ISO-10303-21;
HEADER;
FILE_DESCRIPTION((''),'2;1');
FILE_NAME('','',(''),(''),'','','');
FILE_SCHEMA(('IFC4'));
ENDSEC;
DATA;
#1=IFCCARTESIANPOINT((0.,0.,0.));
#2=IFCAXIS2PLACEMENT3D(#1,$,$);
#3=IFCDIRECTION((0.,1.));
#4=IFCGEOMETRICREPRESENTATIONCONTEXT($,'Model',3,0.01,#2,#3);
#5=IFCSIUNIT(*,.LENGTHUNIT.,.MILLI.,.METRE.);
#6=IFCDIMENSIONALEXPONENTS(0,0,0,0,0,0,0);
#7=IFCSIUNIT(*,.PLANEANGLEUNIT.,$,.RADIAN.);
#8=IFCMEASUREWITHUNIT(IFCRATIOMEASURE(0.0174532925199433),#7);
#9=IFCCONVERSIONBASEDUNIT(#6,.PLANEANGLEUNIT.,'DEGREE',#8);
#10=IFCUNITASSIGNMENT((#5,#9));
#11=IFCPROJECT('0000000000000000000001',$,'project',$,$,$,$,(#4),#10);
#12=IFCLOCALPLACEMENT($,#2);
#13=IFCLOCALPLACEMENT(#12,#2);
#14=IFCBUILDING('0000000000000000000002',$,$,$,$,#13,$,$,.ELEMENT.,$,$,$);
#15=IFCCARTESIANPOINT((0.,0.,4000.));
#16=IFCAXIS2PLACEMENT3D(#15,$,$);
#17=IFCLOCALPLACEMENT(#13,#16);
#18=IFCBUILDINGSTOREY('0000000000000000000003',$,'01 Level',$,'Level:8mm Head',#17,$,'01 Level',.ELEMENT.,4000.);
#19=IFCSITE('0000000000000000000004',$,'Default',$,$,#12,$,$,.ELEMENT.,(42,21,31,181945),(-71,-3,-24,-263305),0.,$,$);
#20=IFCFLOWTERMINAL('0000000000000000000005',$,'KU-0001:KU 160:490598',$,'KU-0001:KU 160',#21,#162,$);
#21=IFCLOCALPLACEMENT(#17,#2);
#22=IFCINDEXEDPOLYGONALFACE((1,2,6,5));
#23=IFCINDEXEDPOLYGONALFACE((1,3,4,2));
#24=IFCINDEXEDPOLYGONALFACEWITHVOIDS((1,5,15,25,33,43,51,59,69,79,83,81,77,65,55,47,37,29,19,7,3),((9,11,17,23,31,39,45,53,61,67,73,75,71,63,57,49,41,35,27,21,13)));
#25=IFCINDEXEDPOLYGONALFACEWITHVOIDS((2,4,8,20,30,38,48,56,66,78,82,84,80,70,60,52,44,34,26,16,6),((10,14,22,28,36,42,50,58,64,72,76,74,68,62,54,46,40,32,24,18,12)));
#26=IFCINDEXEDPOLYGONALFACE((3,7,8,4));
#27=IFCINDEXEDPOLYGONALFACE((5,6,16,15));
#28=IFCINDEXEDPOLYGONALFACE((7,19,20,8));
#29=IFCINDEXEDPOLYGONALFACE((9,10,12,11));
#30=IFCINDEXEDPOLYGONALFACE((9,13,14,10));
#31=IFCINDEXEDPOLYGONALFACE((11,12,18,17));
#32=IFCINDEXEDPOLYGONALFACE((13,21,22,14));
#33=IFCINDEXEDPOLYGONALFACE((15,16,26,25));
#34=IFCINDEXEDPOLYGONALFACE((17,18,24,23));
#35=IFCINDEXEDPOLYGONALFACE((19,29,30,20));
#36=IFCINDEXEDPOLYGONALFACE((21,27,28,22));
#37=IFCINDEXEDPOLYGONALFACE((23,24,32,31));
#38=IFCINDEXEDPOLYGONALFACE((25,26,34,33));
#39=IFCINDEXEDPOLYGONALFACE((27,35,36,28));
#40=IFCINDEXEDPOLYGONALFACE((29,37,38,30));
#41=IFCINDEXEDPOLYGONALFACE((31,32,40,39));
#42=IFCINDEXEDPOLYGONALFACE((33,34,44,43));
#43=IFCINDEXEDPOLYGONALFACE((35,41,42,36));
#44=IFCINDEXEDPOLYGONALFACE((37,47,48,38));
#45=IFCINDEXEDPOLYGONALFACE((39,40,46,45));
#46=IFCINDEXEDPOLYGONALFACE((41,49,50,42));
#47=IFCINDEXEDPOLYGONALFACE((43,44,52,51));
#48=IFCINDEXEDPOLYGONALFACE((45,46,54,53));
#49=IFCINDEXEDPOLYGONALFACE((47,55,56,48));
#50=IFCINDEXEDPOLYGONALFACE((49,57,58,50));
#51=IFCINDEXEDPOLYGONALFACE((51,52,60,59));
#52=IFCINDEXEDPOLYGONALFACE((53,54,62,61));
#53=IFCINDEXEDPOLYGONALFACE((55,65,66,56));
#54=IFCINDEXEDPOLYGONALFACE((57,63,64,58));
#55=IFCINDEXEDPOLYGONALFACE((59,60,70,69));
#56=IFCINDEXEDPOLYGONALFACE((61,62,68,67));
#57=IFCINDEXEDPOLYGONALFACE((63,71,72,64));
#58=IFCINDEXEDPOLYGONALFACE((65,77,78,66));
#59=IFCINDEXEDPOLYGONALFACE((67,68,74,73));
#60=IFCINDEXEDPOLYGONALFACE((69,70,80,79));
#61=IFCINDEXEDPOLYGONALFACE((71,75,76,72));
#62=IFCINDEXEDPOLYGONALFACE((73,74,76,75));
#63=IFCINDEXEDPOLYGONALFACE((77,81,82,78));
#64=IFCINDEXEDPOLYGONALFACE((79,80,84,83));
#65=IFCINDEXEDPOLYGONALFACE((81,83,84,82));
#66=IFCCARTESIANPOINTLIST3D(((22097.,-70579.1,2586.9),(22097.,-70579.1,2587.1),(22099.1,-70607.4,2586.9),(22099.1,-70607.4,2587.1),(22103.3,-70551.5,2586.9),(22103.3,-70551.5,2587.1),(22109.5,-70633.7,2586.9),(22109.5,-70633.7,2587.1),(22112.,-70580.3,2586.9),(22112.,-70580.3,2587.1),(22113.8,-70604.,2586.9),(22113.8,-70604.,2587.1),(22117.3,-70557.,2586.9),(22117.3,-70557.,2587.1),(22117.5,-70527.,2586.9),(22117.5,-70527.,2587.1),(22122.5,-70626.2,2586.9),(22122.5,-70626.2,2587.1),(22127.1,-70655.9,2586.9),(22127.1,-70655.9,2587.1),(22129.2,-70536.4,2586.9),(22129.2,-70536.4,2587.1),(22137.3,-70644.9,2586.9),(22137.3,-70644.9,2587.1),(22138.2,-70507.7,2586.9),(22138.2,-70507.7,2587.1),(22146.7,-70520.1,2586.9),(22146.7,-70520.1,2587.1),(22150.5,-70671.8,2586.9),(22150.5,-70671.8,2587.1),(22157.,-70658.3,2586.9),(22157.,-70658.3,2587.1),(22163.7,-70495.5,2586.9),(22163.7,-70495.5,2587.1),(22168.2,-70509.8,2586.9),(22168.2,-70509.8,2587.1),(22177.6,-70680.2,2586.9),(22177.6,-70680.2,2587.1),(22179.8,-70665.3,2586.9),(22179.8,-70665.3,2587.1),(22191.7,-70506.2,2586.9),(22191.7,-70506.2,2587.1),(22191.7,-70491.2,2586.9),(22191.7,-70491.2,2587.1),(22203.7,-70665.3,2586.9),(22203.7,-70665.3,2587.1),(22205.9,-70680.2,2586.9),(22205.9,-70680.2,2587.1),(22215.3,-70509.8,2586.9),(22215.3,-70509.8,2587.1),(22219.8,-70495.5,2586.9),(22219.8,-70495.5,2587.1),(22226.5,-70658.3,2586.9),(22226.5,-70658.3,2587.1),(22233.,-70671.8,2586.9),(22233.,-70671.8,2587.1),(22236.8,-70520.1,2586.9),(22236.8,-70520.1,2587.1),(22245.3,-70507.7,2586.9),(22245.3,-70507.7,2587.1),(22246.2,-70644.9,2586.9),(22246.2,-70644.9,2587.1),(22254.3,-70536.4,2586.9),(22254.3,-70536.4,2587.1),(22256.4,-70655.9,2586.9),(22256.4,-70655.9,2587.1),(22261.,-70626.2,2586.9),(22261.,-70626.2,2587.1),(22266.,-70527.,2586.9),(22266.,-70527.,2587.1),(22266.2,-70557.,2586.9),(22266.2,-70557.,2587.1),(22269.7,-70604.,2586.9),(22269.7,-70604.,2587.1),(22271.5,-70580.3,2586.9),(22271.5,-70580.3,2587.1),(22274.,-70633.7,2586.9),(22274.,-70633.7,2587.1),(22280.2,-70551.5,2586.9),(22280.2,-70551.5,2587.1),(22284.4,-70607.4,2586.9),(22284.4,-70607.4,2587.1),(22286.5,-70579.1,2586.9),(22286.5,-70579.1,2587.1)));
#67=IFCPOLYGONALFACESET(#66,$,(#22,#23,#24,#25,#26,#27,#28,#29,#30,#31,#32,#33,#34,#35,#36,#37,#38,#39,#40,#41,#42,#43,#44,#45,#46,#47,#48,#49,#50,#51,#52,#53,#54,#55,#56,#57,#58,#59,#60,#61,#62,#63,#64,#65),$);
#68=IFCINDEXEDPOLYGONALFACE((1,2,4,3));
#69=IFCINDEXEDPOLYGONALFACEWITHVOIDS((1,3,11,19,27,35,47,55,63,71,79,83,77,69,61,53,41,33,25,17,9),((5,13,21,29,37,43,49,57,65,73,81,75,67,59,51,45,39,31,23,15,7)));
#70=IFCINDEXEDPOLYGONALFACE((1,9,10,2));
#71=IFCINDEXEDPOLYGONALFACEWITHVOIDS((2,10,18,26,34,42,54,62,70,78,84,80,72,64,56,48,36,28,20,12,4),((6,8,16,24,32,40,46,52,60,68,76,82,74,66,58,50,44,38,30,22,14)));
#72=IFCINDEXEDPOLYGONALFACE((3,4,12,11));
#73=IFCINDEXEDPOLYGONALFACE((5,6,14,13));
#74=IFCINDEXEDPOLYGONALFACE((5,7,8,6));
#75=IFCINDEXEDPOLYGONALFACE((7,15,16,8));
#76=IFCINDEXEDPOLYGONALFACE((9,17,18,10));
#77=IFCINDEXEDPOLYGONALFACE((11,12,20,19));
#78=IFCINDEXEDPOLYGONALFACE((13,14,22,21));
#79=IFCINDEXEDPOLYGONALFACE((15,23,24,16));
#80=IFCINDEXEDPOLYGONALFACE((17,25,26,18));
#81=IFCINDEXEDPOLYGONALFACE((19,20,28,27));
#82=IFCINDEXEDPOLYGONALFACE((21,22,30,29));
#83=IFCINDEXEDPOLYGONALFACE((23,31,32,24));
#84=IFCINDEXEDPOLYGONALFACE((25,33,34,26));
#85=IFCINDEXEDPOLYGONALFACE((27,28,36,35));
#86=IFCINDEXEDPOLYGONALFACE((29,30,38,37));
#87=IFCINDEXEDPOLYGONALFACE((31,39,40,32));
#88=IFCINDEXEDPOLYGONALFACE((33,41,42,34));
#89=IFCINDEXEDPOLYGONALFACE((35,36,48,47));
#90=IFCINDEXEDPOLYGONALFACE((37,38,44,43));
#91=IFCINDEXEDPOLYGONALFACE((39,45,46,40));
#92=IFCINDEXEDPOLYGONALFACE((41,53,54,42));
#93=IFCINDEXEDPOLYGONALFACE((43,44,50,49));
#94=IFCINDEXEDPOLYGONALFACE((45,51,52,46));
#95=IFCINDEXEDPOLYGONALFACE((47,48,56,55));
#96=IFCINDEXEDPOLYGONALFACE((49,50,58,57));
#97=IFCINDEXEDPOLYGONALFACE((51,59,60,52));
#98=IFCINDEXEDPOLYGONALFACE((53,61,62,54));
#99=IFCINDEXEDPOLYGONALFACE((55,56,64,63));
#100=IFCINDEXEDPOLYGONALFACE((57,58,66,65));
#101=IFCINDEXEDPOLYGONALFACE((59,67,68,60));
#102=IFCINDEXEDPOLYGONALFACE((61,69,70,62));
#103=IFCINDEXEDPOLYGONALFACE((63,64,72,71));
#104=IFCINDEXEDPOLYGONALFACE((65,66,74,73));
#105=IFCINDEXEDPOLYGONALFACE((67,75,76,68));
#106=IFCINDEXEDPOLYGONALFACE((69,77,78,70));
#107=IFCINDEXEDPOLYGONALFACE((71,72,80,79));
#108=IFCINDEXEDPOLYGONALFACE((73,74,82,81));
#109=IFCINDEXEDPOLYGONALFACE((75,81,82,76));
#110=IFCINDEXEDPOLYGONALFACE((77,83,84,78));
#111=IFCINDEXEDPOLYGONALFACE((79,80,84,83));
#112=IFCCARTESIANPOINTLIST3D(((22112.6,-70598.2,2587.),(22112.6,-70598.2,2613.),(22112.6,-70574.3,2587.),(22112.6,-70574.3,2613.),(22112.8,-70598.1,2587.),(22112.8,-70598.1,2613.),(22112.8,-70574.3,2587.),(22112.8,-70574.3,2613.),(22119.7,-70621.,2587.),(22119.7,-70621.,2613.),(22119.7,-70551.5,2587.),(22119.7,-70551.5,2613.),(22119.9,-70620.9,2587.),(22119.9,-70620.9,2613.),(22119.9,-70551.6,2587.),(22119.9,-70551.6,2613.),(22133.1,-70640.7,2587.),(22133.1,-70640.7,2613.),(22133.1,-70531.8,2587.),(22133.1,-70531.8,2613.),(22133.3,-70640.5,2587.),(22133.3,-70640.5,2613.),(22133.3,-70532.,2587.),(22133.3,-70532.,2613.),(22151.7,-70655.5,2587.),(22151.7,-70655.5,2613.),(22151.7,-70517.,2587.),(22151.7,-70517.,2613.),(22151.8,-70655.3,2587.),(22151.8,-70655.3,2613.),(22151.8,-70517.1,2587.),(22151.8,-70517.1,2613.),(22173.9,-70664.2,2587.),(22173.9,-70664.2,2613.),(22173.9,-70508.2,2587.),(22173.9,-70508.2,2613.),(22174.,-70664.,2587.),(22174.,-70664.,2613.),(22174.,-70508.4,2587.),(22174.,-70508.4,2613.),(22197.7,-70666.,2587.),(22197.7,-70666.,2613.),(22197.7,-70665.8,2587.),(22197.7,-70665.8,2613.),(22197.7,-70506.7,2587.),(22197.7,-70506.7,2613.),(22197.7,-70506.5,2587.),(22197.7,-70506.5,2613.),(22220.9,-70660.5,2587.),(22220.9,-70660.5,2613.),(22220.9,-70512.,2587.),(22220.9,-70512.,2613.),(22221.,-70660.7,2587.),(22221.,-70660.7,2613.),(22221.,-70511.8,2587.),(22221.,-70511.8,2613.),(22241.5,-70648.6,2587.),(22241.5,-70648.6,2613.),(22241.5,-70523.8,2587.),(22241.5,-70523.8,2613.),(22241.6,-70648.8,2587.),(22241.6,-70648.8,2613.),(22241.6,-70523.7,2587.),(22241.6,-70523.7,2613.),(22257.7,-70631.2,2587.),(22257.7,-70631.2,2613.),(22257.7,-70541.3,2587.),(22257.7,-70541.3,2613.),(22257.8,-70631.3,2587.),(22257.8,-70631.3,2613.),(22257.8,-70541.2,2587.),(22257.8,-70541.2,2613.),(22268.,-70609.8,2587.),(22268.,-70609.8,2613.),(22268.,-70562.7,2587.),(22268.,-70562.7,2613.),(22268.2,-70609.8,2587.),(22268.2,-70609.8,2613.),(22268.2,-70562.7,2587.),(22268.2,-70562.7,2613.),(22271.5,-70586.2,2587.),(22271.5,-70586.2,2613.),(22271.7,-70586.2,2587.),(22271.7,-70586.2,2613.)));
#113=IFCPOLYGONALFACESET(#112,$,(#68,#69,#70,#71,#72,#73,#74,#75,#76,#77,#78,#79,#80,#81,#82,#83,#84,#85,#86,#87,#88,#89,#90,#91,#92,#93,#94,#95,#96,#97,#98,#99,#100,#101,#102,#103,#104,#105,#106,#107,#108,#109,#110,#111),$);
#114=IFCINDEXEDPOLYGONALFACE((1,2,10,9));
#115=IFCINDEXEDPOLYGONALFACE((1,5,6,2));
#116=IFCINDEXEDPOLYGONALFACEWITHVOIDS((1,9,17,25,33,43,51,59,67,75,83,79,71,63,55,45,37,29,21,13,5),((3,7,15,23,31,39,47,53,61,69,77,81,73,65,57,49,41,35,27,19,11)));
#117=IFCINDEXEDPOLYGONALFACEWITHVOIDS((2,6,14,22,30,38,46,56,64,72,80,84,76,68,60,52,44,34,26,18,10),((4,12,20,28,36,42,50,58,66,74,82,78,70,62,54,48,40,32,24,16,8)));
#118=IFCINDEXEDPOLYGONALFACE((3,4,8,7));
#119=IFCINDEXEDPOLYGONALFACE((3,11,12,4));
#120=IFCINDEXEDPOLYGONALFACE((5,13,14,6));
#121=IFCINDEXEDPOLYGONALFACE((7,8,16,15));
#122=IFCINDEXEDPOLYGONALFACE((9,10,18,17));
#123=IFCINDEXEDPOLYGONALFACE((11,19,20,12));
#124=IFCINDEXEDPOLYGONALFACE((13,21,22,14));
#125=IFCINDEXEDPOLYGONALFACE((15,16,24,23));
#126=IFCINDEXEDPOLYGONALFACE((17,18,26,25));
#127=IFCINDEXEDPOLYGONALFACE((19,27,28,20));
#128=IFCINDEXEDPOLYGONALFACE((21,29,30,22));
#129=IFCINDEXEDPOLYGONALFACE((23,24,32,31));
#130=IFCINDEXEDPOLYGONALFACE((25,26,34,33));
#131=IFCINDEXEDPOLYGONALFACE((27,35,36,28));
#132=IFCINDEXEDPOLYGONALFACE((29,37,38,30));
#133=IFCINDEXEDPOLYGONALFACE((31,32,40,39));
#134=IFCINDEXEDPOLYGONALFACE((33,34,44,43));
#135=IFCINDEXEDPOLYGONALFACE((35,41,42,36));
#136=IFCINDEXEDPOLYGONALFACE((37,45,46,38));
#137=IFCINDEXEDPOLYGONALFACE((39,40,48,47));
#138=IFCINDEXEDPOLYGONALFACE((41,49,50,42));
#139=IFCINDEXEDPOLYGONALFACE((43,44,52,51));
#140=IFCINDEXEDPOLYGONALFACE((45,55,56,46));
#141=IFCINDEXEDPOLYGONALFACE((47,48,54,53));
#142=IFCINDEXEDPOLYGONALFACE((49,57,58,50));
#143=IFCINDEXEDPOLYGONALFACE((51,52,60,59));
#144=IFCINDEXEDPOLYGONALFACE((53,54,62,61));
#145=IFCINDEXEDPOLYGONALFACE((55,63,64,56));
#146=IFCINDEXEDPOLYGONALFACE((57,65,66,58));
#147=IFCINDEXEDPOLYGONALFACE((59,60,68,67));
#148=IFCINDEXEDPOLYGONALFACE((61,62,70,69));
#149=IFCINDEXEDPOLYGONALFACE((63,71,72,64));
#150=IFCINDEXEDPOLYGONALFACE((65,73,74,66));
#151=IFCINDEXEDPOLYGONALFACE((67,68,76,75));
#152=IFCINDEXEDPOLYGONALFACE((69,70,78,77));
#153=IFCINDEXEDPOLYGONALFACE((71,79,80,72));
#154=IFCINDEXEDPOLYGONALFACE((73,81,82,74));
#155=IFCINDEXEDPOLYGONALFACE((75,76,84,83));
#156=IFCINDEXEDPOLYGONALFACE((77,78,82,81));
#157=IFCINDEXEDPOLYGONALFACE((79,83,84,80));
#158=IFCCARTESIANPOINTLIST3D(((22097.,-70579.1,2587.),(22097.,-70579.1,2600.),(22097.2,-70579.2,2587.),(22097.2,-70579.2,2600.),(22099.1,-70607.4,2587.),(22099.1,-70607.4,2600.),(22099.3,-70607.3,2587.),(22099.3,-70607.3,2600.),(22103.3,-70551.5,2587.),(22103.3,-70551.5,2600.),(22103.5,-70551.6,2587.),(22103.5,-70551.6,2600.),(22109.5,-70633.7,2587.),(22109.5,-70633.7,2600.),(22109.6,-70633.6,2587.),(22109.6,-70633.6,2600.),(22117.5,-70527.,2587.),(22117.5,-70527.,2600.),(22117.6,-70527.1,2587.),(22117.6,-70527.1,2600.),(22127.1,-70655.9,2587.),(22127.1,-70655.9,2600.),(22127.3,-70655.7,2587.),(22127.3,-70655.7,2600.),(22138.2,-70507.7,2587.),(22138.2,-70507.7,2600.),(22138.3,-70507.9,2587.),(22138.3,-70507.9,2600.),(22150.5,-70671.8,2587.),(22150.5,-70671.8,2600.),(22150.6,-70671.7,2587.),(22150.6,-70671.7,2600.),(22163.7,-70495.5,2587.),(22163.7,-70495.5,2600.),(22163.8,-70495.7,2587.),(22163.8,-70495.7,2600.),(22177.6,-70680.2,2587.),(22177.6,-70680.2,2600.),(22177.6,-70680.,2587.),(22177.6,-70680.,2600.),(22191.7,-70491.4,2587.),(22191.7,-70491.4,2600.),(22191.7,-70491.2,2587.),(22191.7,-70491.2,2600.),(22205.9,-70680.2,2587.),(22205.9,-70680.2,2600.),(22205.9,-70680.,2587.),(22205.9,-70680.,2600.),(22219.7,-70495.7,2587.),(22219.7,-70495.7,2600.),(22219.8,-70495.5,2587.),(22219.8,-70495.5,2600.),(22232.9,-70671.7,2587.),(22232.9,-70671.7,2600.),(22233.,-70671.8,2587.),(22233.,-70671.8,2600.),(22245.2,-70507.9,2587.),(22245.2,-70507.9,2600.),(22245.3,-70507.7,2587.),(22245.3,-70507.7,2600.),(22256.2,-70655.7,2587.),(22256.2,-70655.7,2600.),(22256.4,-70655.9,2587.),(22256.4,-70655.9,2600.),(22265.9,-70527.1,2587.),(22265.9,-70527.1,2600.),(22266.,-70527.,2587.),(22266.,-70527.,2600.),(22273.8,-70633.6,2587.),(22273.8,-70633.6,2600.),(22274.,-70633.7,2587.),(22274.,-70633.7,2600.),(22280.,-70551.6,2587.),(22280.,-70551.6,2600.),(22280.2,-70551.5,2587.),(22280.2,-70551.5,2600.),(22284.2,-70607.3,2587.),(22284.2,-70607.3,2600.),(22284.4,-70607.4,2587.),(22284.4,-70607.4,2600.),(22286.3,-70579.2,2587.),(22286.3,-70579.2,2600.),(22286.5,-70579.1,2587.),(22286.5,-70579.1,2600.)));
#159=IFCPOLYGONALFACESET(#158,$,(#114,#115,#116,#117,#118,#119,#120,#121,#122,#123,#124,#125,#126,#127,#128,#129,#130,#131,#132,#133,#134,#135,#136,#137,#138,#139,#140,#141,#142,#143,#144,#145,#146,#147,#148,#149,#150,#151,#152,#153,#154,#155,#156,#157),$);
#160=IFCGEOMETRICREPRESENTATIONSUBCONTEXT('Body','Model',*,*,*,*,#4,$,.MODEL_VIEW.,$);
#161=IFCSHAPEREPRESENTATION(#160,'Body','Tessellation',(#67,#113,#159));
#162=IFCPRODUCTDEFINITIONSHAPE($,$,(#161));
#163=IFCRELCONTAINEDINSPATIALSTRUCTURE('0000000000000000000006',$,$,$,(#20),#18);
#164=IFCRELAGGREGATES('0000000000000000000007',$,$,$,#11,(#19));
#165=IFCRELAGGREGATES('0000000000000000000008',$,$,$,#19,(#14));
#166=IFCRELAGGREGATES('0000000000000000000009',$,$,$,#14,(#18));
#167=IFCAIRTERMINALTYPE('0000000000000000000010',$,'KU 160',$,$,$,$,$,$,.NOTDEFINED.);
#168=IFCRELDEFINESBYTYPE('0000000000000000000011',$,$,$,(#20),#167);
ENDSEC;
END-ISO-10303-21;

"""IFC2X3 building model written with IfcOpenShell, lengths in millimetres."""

from ifc_helpers import new_model, entity, si_unit, converted_unit, direction, frame, frame_2d, origin, place, context, subcontext, project, spatial, hollow_circle, extrude, source, transform, mapped, type_object, type_shapes, element, save


model = new_model("IFC2X3")

# Units and contexts
model_context = context("Model", 3, precision=0.01, world=origin(), true_north=direction((0.0, 1.0)))
body_context = subcontext(model_context, "Body", "Model", "MODEL_VIEW")
ifc_project = project(units=[si_unit("LENGTHUNIT", "METRE", prefix="MILLI"), converted_unit("PLANEANGLEUNIT", "DEGREE", entity("IfcRatioMeasure", 0.0174532925199433), si_unit("PLANEANGLEUNIT", "RADIAN"), dimensions=[0, 0, 0, 0, 0, 0, 0])], contexts=[model_context])

# Site, building, storey
site_placement = place(None, origin())
site = spatial("IfcSite", under=ifc_project, at=site_placement, Name="Default", CompositionType="ELEMENT", RefLatitude=(42, 21, 31, 181945), RefLongitude=(-71, -3, -24, -263305), RefElevation=0.0)
building_placement = place(site_placement, origin())
building = spatial("IfcBuilding", under=site, at=building_placement, CompositionType="ELEMENT")
storey_placement = place(building_placement, frame((0.0, 0.0, 4000.0)))
storey = spatial("IfcBuildingStorey", under=building, at=storey_placement, Name="01 Level", ObjectType="Level:8mm Head", LongName="01 Level", CompositionType="ELEMENT", Elevation=4000.0)

# Flow terminal
air_terminal_type_1 = type_object("IfcAirTerminalType", Name="KU 160", PredefinedType="NOTDEFINED")
shared_shape_1 = source(origin(), body_context, "Body", "SweptSolid", [
    extrude(hollow_circle(Radius=95.0, WallThickness=15.0, at=frame_2d((0.0, 0.0), x_axis=(1.0, 0.0))), frame((12.9, 0.0, 0.0), z_axis=(1.0, 0.0, 0.0), x_axis=(0.0, 1.0, 0.0)), (0.0, 0.0, 1.0), 0.2),
    extrude(hollow_circle(Radius=80.0, WallThickness=0.2, at=frame_2d((0.0, 0.0), x_axis=(1.0, 0.0))), frame((-13.0, 0.0, 0.0), z_axis=(1.0, 0.0, 0.0), x_axis=(0.0, 0.0, 1.0)), (0.0, 0.0, 1.0), 26.0),
    extrude(hollow_circle(Radius=95.0, WallThickness=0.2, at=frame_2d((0.0, 0.0), x_axis=(1.0, 0.0))), frame((0.0, 0.0, 0.0), z_axis=(1.0, 0.0, 0.0), x_axis=(0.0, 1.0, 0.0)), (0.0, 0.0, 1.0), 13.0),
])
type_shapes(air_terminal_type_1, [shared_shape_1])
for number, where, z_axis, x_axis, name in (
    (1, (22191.7, -70586.2, 2600.0), (1.0, 0.0, 0.0), (0.0, 0.0, -1.0), "KU-0001:KU 160:490598"),
):
    element("IfcFlowTerminal", number, at=place(storey_placement, frame(where, z_axis=z_axis, x_axis=x_axis)), inside=storey, type_object=air_terminal_type_1, Name=name, ObjectType="KU-0001:KU 160", context=body_context, shape_type="MappedRepresentation", body=[
        mapped(shared_shape_1, transform((0.0, 0.0, 0.0), scale=1.0)),
    ])

save(model, "model.ifc")
